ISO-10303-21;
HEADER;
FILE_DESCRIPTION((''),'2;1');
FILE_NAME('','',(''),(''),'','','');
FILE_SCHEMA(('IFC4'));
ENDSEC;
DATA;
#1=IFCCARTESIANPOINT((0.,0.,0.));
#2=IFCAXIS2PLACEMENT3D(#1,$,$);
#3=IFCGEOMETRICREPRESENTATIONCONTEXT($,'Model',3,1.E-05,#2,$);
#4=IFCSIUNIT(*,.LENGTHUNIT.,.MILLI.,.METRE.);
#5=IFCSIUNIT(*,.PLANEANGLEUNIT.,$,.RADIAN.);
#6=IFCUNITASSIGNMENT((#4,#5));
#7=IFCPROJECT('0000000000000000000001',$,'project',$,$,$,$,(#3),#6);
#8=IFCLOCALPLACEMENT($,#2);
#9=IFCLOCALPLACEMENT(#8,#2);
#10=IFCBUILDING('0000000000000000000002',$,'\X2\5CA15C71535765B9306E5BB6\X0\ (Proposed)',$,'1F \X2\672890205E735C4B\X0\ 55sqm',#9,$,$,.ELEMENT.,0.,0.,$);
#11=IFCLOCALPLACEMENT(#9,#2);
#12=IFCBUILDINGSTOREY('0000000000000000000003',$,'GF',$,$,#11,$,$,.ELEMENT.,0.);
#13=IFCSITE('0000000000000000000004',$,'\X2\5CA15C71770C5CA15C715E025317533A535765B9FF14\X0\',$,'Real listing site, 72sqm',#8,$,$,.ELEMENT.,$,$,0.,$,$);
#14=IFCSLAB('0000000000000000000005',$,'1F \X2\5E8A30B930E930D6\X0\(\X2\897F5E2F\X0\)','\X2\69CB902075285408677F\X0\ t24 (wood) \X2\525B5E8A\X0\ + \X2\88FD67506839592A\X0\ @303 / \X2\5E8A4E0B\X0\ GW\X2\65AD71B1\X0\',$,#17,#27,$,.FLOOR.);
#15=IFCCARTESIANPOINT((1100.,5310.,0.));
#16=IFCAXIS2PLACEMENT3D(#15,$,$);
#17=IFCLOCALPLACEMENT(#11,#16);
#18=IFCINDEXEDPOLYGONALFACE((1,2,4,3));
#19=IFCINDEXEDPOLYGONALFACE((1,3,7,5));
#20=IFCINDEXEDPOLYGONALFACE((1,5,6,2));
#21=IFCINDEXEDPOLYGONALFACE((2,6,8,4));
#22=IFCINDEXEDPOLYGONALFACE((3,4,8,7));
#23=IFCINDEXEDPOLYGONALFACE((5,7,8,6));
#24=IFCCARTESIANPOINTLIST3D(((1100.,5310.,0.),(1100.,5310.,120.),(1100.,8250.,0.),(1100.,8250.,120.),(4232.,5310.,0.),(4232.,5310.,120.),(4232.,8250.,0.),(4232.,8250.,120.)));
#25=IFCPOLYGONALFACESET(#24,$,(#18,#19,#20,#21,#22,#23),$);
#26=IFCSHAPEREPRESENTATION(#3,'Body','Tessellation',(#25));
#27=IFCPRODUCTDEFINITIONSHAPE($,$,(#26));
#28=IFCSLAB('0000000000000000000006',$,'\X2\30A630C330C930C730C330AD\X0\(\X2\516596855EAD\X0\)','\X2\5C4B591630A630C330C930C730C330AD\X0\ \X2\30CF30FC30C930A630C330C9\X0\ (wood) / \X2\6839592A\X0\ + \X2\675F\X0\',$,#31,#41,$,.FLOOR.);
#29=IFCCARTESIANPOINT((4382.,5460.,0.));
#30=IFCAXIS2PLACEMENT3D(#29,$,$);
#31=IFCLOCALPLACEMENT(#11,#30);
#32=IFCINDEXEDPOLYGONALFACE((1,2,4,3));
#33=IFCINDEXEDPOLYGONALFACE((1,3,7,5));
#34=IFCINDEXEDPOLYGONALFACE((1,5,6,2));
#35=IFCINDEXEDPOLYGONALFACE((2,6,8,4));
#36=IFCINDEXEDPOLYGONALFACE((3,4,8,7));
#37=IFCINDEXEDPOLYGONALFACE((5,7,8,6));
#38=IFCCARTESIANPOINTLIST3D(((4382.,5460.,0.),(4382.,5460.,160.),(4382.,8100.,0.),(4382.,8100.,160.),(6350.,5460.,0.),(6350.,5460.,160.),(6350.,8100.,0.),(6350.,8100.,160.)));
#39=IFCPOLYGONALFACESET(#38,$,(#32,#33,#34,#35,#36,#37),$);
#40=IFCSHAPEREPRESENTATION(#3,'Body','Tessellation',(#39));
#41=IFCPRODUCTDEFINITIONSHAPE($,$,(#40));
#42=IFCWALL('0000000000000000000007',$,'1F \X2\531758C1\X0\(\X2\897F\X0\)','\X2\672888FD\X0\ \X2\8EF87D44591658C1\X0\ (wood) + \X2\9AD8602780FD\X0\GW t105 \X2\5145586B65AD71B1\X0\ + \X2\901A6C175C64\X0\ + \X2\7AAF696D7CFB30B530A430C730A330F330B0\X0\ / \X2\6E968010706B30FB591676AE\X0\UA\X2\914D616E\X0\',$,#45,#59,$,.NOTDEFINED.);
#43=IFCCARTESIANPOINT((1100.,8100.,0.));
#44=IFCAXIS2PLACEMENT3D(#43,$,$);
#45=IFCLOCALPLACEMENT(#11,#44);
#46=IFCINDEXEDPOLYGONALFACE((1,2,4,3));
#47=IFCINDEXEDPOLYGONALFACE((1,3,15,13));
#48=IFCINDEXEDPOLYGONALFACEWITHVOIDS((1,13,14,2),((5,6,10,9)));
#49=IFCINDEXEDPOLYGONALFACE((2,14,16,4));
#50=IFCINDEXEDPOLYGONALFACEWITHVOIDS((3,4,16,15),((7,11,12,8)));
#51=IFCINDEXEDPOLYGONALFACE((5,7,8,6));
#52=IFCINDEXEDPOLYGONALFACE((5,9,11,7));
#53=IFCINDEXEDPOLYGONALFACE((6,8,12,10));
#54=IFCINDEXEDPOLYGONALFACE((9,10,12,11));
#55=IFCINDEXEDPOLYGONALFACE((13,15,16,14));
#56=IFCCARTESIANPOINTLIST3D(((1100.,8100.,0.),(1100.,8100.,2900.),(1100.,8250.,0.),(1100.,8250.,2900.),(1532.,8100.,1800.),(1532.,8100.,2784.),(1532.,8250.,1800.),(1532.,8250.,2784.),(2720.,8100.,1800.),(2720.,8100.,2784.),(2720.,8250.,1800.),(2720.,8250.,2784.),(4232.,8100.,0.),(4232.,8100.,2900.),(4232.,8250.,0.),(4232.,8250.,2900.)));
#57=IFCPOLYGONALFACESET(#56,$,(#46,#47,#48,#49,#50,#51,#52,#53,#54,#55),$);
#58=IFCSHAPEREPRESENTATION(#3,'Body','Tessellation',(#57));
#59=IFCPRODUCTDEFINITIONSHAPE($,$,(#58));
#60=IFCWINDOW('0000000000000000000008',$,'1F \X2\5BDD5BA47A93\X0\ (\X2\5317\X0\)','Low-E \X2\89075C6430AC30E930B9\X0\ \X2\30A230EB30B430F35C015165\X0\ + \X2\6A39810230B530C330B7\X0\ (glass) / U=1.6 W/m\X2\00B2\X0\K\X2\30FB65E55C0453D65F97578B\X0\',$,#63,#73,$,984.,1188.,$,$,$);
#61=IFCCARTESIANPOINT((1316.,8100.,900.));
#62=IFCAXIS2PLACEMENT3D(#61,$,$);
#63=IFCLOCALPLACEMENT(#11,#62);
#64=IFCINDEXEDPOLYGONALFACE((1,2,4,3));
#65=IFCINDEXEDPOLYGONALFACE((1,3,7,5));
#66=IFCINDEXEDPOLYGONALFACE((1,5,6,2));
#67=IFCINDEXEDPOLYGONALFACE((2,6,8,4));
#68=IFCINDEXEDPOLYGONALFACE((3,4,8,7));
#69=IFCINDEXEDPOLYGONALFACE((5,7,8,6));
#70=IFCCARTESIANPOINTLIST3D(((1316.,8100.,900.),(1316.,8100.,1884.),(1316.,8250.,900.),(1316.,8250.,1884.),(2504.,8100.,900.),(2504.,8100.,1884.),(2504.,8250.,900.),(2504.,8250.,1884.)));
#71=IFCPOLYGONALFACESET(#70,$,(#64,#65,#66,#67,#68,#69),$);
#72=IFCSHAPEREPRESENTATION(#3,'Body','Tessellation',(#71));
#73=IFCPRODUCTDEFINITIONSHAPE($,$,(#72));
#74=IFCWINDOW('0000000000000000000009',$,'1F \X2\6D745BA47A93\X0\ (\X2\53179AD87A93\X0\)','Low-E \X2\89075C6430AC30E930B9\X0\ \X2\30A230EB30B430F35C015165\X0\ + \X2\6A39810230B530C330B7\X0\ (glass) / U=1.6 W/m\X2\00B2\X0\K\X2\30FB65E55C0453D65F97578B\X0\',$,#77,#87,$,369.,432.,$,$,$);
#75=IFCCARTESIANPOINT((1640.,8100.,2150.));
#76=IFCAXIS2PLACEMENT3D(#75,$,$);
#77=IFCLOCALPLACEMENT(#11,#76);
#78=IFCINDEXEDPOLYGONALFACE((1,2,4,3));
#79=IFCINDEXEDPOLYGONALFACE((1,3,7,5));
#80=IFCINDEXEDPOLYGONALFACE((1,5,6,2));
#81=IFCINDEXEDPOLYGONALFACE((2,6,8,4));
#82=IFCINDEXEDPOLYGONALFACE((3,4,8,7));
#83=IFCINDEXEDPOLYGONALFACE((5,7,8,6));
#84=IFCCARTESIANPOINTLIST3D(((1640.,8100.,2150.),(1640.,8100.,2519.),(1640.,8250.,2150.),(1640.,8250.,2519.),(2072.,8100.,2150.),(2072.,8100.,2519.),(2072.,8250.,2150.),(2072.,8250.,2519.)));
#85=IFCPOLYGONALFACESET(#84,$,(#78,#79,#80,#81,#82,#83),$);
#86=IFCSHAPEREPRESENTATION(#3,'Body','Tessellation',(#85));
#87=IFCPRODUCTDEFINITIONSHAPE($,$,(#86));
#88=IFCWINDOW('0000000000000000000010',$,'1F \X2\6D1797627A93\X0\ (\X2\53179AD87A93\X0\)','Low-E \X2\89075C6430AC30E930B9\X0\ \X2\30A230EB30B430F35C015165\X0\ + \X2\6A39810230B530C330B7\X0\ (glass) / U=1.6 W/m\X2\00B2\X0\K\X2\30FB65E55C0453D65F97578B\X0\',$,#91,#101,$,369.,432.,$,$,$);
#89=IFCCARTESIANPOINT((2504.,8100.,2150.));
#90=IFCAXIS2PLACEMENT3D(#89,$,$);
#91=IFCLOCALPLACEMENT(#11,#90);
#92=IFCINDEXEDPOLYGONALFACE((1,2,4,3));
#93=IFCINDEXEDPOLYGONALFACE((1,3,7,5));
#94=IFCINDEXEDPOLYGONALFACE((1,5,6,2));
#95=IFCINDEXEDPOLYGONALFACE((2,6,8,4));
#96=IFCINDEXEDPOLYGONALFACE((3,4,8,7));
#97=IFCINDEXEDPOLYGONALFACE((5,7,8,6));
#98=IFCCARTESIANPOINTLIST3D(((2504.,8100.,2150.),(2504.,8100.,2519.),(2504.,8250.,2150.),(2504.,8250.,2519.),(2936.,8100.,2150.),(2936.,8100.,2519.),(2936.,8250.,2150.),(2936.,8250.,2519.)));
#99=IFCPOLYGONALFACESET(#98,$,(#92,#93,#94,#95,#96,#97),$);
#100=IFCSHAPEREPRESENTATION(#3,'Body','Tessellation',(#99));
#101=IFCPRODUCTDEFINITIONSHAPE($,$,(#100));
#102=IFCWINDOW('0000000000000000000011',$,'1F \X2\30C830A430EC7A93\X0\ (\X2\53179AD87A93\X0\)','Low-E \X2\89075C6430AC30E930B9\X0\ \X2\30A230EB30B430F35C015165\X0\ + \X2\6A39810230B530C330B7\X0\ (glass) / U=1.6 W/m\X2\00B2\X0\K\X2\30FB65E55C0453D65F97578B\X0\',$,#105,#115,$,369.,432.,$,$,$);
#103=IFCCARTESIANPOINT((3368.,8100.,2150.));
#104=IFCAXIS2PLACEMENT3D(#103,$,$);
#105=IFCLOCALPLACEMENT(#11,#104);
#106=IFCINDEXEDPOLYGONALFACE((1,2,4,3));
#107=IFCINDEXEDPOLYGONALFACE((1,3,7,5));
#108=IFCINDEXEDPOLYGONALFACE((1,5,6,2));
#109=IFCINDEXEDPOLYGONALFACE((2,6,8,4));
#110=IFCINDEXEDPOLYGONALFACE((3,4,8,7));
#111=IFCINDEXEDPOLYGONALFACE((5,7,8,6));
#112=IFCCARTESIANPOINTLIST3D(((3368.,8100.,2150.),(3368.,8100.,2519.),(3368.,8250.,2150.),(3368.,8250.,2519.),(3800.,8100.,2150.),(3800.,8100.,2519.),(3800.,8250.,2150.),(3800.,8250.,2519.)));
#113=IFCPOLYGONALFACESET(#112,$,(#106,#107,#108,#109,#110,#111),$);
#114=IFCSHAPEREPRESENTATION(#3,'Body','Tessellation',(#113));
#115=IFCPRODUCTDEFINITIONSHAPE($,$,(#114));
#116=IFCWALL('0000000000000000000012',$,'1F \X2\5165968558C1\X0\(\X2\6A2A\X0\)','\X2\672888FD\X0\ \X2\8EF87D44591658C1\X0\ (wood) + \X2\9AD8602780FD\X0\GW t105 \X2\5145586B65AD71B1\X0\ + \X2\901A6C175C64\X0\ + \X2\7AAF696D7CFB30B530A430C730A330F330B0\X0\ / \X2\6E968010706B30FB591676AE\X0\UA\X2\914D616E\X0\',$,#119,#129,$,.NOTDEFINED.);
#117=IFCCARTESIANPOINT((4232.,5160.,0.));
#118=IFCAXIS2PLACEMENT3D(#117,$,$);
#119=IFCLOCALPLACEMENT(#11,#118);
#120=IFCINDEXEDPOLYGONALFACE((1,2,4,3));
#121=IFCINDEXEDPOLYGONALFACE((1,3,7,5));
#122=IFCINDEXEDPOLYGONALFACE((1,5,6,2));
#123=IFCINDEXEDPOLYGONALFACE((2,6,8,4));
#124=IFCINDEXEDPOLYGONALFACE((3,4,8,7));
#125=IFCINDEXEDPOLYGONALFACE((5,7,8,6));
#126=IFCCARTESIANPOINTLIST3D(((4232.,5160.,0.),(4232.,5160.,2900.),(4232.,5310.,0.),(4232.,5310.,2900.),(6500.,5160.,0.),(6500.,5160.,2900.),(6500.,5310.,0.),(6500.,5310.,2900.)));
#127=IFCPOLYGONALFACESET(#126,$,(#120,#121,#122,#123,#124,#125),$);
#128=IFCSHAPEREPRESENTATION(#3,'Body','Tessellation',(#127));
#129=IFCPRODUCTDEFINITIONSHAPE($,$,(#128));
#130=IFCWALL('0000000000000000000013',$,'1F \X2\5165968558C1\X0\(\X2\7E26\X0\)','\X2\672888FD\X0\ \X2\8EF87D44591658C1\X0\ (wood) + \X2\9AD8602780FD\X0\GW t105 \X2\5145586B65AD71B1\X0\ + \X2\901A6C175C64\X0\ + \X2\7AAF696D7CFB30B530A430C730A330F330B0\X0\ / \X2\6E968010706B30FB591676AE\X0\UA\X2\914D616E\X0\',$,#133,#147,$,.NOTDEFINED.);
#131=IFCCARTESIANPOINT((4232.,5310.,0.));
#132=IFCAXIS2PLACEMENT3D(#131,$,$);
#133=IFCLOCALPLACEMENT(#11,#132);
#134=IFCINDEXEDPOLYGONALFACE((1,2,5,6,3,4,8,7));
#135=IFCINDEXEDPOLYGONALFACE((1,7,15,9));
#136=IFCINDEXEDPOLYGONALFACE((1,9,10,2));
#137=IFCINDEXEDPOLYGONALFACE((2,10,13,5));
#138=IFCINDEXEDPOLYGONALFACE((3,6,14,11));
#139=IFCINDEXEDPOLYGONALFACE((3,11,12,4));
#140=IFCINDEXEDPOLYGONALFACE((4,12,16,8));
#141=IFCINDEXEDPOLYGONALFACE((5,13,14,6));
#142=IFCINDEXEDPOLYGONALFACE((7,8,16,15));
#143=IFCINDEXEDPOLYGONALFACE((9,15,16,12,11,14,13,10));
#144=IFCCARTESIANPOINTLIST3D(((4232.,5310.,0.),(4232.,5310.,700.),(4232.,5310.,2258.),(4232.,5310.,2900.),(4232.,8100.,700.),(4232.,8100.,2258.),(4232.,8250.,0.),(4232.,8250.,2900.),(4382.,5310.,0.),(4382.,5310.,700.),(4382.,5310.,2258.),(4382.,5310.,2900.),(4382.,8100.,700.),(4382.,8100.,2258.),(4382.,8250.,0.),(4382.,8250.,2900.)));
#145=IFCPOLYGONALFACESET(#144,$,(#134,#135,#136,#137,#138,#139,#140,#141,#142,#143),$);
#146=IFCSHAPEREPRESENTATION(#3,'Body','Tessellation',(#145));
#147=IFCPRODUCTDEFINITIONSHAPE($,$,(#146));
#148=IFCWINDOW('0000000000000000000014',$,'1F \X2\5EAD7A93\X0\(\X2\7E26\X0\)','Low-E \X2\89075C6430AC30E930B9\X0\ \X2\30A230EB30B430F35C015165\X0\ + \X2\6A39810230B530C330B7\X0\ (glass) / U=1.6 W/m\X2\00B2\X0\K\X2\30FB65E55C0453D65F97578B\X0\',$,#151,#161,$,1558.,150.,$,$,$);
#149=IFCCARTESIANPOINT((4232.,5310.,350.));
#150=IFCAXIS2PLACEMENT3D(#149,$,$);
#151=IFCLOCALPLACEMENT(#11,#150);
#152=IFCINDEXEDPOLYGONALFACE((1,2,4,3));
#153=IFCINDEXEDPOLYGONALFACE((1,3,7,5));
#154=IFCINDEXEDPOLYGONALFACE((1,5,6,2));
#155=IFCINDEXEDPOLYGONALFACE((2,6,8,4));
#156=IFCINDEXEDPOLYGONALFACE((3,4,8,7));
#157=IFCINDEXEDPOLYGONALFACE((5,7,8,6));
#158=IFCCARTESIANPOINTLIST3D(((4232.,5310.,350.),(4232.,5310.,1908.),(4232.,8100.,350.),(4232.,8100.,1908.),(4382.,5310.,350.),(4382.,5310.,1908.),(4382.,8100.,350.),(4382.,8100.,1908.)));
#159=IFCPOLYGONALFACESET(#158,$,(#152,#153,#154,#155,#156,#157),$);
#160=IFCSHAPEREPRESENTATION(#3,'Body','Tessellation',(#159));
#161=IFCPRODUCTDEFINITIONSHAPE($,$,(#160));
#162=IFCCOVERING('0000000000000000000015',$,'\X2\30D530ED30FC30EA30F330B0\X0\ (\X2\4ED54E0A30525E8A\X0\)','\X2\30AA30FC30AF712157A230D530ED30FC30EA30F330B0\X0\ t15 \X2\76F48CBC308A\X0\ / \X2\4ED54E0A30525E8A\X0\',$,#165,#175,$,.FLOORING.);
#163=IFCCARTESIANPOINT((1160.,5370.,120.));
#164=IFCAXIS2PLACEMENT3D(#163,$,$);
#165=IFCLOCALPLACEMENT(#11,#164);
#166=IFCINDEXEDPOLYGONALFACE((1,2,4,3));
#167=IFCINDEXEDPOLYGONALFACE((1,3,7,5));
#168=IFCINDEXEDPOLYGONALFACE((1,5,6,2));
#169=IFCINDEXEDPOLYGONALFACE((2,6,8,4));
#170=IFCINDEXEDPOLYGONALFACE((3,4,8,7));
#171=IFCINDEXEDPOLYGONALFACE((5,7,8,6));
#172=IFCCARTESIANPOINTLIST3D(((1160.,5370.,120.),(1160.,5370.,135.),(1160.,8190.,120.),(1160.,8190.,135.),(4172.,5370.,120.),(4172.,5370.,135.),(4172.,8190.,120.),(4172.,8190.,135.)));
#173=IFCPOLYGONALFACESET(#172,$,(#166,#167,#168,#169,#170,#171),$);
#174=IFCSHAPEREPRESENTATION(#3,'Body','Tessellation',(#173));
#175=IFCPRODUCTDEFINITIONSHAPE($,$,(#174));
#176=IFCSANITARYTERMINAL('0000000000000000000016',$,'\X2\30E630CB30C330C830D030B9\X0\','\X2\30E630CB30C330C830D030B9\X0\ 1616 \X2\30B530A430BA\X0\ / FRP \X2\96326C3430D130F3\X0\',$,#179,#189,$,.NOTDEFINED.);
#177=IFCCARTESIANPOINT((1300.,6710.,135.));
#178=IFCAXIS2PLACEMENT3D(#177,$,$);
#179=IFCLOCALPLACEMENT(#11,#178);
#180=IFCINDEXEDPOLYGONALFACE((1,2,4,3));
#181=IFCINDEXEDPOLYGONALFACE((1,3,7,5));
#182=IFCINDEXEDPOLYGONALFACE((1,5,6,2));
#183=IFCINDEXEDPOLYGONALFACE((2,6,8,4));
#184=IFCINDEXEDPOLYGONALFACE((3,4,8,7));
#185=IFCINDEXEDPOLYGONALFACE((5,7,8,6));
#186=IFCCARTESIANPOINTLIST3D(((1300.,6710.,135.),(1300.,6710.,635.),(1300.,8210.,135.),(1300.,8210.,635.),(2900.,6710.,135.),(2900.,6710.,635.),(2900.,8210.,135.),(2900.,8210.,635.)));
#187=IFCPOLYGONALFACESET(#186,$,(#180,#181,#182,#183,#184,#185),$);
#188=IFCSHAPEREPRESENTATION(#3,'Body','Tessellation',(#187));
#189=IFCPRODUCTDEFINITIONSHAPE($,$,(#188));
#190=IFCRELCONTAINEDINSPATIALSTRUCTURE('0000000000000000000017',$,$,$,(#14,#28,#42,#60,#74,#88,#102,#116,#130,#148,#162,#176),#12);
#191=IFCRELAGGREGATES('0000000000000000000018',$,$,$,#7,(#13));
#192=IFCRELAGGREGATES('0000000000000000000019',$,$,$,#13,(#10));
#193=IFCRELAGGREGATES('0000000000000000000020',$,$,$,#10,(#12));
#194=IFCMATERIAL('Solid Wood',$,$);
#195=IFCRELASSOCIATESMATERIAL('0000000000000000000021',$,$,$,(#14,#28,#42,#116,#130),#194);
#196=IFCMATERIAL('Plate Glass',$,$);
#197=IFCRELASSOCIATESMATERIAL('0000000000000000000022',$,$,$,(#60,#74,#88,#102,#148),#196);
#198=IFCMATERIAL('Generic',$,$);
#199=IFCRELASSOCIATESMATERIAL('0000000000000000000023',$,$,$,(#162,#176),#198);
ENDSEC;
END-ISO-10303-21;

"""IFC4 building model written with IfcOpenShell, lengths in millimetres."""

from ifc_helpers import new_model, si_unit, frame, frame_2d, origin, place, context, project, spatial, rectangle, extrude, material, element, fill, save


model = new_model("IFC4")

# Units and contexts
model_context = context("Model", 3, precision=1e-05, world=origin())
ifc_project = project(units=[si_unit("LENGTHUNIT", "METRE", prefix="MILLI"), si_unit("PLANEANGLEUNIT", "RADIAN")], contexts=[model_context])

# Site, building, storey
site_placement = place(None, origin())
site = spatial("IfcSite", under=ifc_project, at=site_placement, Name="岡山県岡山市北区南方４", ObjectType="Real listing site, 72sqm", CompositionType="ELEMENT", RefElevation=0.0)
building_placement = place(site_placement, origin())
building = spatial("IfcBuilding", under=site, at=building_placement, Name="岡山南方の家 (Proposed)", ObjectType="1F 木造平屋 55sqm", CompositionType="ELEMENT", ElevationOfRefHeight=0.0, ElevationOfTerrain=0.0)
storey_placement = place(building_placement, origin())
storey = spatial("IfcBuildingStorey", under=building, at=storey_placement, Name="GF", CompositionType="ELEMENT", Elevation=0.0)

# Slabs
ifc_material_1 = material(Name="Solid Wood")
slab_1_placement = place(storey_placement, frame((1100.0, 5310.0, 0.0)))
element("IfcSlab", 1, at=slab_1_placement, inside=storey, material=ifc_material_1, Name="1F 床スラブ(西帯)", Description="構造用合板 t24 (wood) 剛床 + 製材根太 @303 / 床下 GW断熱", PredefinedType="FLOOR", context=model_context, shape_type="SweptSolid", body=[
    extrude(rectangle(XDim=3132.0, YDim=2940.0, at=frame_2d((1566.0, 1470.0))), frame((1100.0, 5310.0, 0.0)), (0.0, 0.0, 1.0), 120.0),
])
slab_2_placement = place(storey_placement, frame((4382.0, 5460.0, 0.0)))
element("IfcSlab", 2, at=slab_2_placement, inside=storey, material=ifc_material_1, Name="ウッドデッキ(入隅庭)", Description="屋外ウッドデッキ ハードウッド (wood) / 根太 + 束", PredefinedType="FLOOR", context=model_context, shape_type="SweptSolid", body=[
    extrude(rectangle(XDim=1968.0, YDim=2640.0, at=frame_2d((984.0, 1320.0))), frame((4382.0, 5460.0, 0.0)), (0.0, 0.0, 1.0), 160.0),
])

# Wall, openings, windows
wall_1_placement = place(storey_placement, frame((1100.0, 8100.0, 0.0)))
wall_1 = element("IfcWall", 3, at=wall_1_placement, inside=storey, material=ifc_material_1, Name="1F 北壁(西)", Description="木製 軸組外壁 (wood) + 高性能GW t105 充填断熱 + 通気層 + 窯業系サイディング / 準耐火・外皮UA配慮", PredefinedType="NOTDEFINED", context=model_context, shape_type="SweptSolid", body=[
    extrude(rectangle(XDim=3132.0, YDim=150.0, at=frame_2d((1566.0, 75.0))), frame((1100.0, 8100.0, 0.0)), (0.0, 0.0, 1.0), 2900.0),
])
opening_1_placement = place(storey_placement, frame((1316.0, 8100.0, 900.0)))
opening_1 = element("IfcOpeningElement", 4, at=opening_1_placement, cuts=wall_1, PredefinedType="NOTDEFINED", context=model_context, shape_type="SweptSolid", body=[
    extrude(rectangle(XDim=1188.0, YDim=150.0, at=frame_2d((594.0, 75.0))), frame((1316.0, 8100.0, 900.0)), (0.0, 0.0, 1.0), 984.0),
])
opening_2_placement = place(storey_placement, frame((1640.0, 8100.0, 2150.0)))
opening_2 = element("IfcOpeningElement", 5, at=opening_2_placement, cuts=wall_1, PredefinedType="NOTDEFINED", context=model_context, shape_type="SweptSolid", body=[
    extrude(rectangle(XDim=432.0, YDim=150.0, at=frame_2d((216.0, 75.0))), frame((1640.0, 8100.0, 2150.0)), (0.0, 0.0, 1.0), 369.0),
])
opening_3_placement = place(storey_placement, frame((2504.0, 8100.0, 2150.0)))
opening_3 = element("IfcOpeningElement", 6, at=opening_3_placement, cuts=wall_1, PredefinedType="NOTDEFINED", context=model_context, shape_type="SweptSolid", body=[
    extrude(rectangle(XDim=432.0, YDim=150.0, at=frame_2d((216.0, 75.0))), frame((2504.0, 8100.0, 2150.0)), (0.0, 0.0, 1.0), 369.0),
])
opening_4_placement = place(storey_placement, frame((3368.0, 8100.0, 2150.0)))
opening_4 = element("IfcOpeningElement", 7, at=opening_4_placement, cuts=wall_1, PredefinedType="NOTDEFINED", context=model_context, shape_type="SweptSolid", body=[
    extrude(rectangle(XDim=432.0, YDim=150.0, at=frame_2d((216.0, 75.0))), frame((3368.0, 8100.0, 2150.0)), (0.0, 0.0, 1.0), 369.0),
])
ifc_material_2 = material(Name="Plate Glass")
window_1_placement = place(storey_placement, frame((1316.0, 8100.0, 900.0)))
window_1 = element("IfcWindow", 8, at=window_1_placement, inside=storey, material=ifc_material_2, Name="1F 寝室窓 (北)", Description="Low-E 複層ガラス アルゴン封入 + 樹脂サッシ (glass) / U=1.6 W/m²K・日射取得型", OverallHeight=984.0, OverallWidth=1188.0, context=model_context, shape_type="SweptSolid", body=[
    extrude(rectangle(XDim=1188.0, YDim=150.0, at=frame_2d((594.0, 75.0))), frame((1316.0, 8100.0, 900.0)), (0.0, 0.0, 1.0), 984.0),
])
fill(opening_1, window_1)
window_2_placement = place(storey_placement, frame((1640.0, 8100.0, 2150.0)))
window_2 = element("IfcWindow", 9, at=window_2_placement, inside=storey, material=ifc_material_2, Name="1F 浴室窓 (北高窓)", Description="Low-E 複層ガラス アルゴン封入 + 樹脂サッシ (glass) / U=1.6 W/m²K・日射取得型", OverallHeight=369.0, OverallWidth=432.0, context=model_context, shape_type="SweptSolid", body=[
    extrude(rectangle(XDim=432.0, YDim=150.0, at=frame_2d((216.0, 75.0))), frame((1640.0, 8100.0, 2150.0)), (0.0, 0.0, 1.0), 369.0),
])
fill(opening_2, window_2)
window_3_placement = place(storey_placement, frame((2504.0, 8100.0, 2150.0)))
window_3 = element("IfcWindow", 10, at=window_3_placement, inside=storey, material=ifc_material_2, Name="1F 洗面窓 (北高窓)", Description="Low-E 複層ガラス アルゴン封入 + 樹脂サッシ (glass) / U=1.6 W/m²K・日射取得型", OverallHeight=369.0, OverallWidth=432.0, context=model_context, shape_type="SweptSolid", body=[
    extrude(rectangle(XDim=432.0, YDim=150.0, at=frame_2d((216.0, 75.0))), frame((2504.0, 8100.0, 2150.0)), (0.0, 0.0, 1.0), 369.0),
])
fill(opening_3, window_3)
window_4_placement = place(storey_placement, frame((3368.0, 8100.0, 2150.0)))
window_4 = element("IfcWindow", 11, at=window_4_placement, inside=storey, material=ifc_material_2, Name="1F トイレ窓 (北高窓)", Description="Low-E 複層ガラス アルゴン封入 + 樹脂サッシ (glass) / U=1.6 W/m²K・日射取得型", OverallHeight=369.0, OverallWidth=432.0, context=model_context, shape_type="SweptSolid", body=[
    extrude(rectangle(XDim=432.0, YDim=150.0, at=frame_2d((216.0, 75.0))), frame((3368.0, 8100.0, 2150.0)), (0.0, 0.0, 1.0), 369.0),
])
fill(opening_4, window_4)

# Wall
wall_2_placement = place(storey_placement, frame((4232.0, 5160.0, 0.0)))
element("IfcWall", 12, at=wall_2_placement, inside=storey, material=ifc_material_1, Name="1F 入隅壁(横)", Description="木製 軸組外壁 (wood) + 高性能GW t105 充填断熱 + 通気層 + 窯業系サイディング / 準耐火・外皮UA配慮", PredefinedType="NOTDEFINED", context=model_context, shape_type="SweptSolid", body=[
    extrude(rectangle(XDim=2268.0, YDim=150.0, at=frame_2d((1134.0, 75.0))), frame((4232.0, 5160.0, 0.0)), (0.0, 0.0, 1.0), 2900.0),
])

# Wall, opening, window
wall_3_placement = place(storey_placement, frame((4232.0, 5310.0, 0.0)))
wall_3 = element("IfcWall", 13, at=wall_3_placement, inside=storey, material=ifc_material_1, Name="1F 入隅壁(縦)", Description="木製 軸組外壁 (wood) + 高性能GW t105 充填断熱 + 通気層 + 窯業系サイディング / 準耐火・外皮UA配慮", PredefinedType="NOTDEFINED", context=model_context, shape_type="SweptSolid", body=[
    extrude(rectangle(XDim=150.0, YDim=2940.0, at=frame_2d((75.0, 1470.0))), frame((4232.0, 5310.0, 0.0)), (0.0, 0.0, 1.0), 2900.0),
])
opening_5_placement = place(storey_placement, frame((4232.0, 5310.0, 350.0)))
opening_5 = element("IfcOpeningElement", 14, at=opening_5_placement, cuts=wall_3, PredefinedType="NOTDEFINED", context=model_context, shape_type="SweptSolid", body=[
    extrude(rectangle(XDim=150.0, YDim=2790.0, at=frame_2d((75.0, 1395.0))), frame((4232.0, 5310.0, 350.0)), (0.0, 0.0, 1.0), 1558.0),
])
window_5_placement = place(storey_placement, frame((4232.0, 5310.0, 350.0)))
window_5 = element("IfcWindow", 15, at=window_5_placement, inside=storey, material=ifc_material_2, Name="1F 庭窓(縦)", Description="Low-E 複層ガラス アルゴン封入 + 樹脂サッシ (glass) / U=1.6 W/m²K・日射取得型", OverallHeight=1558.0, OverallWidth=150.0, context=model_context, shape_type="SweptSolid", body=[
    extrude(rectangle(XDim=150.0, YDim=2790.0, at=frame_2d((75.0, 1395.0))), frame((4232.0, 5310.0, 350.0)), (0.0, 0.0, 1.0), 1558.0),
])
fill(opening_5, window_5)

# Covering
ifc_material_3 = material(Name="Generic")
covering_placement = place(storey_placement, frame((1160.0, 5370.0, 120.0)))
element("IfcCovering", 16, at=covering_placement, inside=storey, material=ifc_material_3, Name="フローリング (仕上げ床)", Description="オーク無垢フローリング t15 直貼り / 仕上げ床", PredefinedType="FLOORING", context=model_context, shape_type="SweptSolid", body=[
    extrude(rectangle(XDim=3012.0, YDim=2820.0, at=frame_2d((1506.0, 1410.0))), frame((1160.0, 5370.0, 120.0)), (0.0, 0.0, 1.0), 15.0),
])

# Sanitary terminal
sanitary_terminal_1_placement = place(storey_placement, frame((1300.0, 6710.0, 135.0)))
element("IfcSanitaryTerminal", 17, at=sanitary_terminal_1_placement, inside=storey, material=ifc_material_3, Name="ユニットバス", Description="ユニットバス 1616 サイズ / FRP 防水パン", PredefinedType="NOTDEFINED", context=model_context, shape_type="SweptSolid", body=[
    extrude(rectangle(XDim=1600.0, YDim=1500.0, at=frame_2d((800.0, 750.0))), frame((1300.0, 6710.0, 135.0)), (0.0, 0.0, 1.0), 500.0),
])

save(model, "model.ifc")
